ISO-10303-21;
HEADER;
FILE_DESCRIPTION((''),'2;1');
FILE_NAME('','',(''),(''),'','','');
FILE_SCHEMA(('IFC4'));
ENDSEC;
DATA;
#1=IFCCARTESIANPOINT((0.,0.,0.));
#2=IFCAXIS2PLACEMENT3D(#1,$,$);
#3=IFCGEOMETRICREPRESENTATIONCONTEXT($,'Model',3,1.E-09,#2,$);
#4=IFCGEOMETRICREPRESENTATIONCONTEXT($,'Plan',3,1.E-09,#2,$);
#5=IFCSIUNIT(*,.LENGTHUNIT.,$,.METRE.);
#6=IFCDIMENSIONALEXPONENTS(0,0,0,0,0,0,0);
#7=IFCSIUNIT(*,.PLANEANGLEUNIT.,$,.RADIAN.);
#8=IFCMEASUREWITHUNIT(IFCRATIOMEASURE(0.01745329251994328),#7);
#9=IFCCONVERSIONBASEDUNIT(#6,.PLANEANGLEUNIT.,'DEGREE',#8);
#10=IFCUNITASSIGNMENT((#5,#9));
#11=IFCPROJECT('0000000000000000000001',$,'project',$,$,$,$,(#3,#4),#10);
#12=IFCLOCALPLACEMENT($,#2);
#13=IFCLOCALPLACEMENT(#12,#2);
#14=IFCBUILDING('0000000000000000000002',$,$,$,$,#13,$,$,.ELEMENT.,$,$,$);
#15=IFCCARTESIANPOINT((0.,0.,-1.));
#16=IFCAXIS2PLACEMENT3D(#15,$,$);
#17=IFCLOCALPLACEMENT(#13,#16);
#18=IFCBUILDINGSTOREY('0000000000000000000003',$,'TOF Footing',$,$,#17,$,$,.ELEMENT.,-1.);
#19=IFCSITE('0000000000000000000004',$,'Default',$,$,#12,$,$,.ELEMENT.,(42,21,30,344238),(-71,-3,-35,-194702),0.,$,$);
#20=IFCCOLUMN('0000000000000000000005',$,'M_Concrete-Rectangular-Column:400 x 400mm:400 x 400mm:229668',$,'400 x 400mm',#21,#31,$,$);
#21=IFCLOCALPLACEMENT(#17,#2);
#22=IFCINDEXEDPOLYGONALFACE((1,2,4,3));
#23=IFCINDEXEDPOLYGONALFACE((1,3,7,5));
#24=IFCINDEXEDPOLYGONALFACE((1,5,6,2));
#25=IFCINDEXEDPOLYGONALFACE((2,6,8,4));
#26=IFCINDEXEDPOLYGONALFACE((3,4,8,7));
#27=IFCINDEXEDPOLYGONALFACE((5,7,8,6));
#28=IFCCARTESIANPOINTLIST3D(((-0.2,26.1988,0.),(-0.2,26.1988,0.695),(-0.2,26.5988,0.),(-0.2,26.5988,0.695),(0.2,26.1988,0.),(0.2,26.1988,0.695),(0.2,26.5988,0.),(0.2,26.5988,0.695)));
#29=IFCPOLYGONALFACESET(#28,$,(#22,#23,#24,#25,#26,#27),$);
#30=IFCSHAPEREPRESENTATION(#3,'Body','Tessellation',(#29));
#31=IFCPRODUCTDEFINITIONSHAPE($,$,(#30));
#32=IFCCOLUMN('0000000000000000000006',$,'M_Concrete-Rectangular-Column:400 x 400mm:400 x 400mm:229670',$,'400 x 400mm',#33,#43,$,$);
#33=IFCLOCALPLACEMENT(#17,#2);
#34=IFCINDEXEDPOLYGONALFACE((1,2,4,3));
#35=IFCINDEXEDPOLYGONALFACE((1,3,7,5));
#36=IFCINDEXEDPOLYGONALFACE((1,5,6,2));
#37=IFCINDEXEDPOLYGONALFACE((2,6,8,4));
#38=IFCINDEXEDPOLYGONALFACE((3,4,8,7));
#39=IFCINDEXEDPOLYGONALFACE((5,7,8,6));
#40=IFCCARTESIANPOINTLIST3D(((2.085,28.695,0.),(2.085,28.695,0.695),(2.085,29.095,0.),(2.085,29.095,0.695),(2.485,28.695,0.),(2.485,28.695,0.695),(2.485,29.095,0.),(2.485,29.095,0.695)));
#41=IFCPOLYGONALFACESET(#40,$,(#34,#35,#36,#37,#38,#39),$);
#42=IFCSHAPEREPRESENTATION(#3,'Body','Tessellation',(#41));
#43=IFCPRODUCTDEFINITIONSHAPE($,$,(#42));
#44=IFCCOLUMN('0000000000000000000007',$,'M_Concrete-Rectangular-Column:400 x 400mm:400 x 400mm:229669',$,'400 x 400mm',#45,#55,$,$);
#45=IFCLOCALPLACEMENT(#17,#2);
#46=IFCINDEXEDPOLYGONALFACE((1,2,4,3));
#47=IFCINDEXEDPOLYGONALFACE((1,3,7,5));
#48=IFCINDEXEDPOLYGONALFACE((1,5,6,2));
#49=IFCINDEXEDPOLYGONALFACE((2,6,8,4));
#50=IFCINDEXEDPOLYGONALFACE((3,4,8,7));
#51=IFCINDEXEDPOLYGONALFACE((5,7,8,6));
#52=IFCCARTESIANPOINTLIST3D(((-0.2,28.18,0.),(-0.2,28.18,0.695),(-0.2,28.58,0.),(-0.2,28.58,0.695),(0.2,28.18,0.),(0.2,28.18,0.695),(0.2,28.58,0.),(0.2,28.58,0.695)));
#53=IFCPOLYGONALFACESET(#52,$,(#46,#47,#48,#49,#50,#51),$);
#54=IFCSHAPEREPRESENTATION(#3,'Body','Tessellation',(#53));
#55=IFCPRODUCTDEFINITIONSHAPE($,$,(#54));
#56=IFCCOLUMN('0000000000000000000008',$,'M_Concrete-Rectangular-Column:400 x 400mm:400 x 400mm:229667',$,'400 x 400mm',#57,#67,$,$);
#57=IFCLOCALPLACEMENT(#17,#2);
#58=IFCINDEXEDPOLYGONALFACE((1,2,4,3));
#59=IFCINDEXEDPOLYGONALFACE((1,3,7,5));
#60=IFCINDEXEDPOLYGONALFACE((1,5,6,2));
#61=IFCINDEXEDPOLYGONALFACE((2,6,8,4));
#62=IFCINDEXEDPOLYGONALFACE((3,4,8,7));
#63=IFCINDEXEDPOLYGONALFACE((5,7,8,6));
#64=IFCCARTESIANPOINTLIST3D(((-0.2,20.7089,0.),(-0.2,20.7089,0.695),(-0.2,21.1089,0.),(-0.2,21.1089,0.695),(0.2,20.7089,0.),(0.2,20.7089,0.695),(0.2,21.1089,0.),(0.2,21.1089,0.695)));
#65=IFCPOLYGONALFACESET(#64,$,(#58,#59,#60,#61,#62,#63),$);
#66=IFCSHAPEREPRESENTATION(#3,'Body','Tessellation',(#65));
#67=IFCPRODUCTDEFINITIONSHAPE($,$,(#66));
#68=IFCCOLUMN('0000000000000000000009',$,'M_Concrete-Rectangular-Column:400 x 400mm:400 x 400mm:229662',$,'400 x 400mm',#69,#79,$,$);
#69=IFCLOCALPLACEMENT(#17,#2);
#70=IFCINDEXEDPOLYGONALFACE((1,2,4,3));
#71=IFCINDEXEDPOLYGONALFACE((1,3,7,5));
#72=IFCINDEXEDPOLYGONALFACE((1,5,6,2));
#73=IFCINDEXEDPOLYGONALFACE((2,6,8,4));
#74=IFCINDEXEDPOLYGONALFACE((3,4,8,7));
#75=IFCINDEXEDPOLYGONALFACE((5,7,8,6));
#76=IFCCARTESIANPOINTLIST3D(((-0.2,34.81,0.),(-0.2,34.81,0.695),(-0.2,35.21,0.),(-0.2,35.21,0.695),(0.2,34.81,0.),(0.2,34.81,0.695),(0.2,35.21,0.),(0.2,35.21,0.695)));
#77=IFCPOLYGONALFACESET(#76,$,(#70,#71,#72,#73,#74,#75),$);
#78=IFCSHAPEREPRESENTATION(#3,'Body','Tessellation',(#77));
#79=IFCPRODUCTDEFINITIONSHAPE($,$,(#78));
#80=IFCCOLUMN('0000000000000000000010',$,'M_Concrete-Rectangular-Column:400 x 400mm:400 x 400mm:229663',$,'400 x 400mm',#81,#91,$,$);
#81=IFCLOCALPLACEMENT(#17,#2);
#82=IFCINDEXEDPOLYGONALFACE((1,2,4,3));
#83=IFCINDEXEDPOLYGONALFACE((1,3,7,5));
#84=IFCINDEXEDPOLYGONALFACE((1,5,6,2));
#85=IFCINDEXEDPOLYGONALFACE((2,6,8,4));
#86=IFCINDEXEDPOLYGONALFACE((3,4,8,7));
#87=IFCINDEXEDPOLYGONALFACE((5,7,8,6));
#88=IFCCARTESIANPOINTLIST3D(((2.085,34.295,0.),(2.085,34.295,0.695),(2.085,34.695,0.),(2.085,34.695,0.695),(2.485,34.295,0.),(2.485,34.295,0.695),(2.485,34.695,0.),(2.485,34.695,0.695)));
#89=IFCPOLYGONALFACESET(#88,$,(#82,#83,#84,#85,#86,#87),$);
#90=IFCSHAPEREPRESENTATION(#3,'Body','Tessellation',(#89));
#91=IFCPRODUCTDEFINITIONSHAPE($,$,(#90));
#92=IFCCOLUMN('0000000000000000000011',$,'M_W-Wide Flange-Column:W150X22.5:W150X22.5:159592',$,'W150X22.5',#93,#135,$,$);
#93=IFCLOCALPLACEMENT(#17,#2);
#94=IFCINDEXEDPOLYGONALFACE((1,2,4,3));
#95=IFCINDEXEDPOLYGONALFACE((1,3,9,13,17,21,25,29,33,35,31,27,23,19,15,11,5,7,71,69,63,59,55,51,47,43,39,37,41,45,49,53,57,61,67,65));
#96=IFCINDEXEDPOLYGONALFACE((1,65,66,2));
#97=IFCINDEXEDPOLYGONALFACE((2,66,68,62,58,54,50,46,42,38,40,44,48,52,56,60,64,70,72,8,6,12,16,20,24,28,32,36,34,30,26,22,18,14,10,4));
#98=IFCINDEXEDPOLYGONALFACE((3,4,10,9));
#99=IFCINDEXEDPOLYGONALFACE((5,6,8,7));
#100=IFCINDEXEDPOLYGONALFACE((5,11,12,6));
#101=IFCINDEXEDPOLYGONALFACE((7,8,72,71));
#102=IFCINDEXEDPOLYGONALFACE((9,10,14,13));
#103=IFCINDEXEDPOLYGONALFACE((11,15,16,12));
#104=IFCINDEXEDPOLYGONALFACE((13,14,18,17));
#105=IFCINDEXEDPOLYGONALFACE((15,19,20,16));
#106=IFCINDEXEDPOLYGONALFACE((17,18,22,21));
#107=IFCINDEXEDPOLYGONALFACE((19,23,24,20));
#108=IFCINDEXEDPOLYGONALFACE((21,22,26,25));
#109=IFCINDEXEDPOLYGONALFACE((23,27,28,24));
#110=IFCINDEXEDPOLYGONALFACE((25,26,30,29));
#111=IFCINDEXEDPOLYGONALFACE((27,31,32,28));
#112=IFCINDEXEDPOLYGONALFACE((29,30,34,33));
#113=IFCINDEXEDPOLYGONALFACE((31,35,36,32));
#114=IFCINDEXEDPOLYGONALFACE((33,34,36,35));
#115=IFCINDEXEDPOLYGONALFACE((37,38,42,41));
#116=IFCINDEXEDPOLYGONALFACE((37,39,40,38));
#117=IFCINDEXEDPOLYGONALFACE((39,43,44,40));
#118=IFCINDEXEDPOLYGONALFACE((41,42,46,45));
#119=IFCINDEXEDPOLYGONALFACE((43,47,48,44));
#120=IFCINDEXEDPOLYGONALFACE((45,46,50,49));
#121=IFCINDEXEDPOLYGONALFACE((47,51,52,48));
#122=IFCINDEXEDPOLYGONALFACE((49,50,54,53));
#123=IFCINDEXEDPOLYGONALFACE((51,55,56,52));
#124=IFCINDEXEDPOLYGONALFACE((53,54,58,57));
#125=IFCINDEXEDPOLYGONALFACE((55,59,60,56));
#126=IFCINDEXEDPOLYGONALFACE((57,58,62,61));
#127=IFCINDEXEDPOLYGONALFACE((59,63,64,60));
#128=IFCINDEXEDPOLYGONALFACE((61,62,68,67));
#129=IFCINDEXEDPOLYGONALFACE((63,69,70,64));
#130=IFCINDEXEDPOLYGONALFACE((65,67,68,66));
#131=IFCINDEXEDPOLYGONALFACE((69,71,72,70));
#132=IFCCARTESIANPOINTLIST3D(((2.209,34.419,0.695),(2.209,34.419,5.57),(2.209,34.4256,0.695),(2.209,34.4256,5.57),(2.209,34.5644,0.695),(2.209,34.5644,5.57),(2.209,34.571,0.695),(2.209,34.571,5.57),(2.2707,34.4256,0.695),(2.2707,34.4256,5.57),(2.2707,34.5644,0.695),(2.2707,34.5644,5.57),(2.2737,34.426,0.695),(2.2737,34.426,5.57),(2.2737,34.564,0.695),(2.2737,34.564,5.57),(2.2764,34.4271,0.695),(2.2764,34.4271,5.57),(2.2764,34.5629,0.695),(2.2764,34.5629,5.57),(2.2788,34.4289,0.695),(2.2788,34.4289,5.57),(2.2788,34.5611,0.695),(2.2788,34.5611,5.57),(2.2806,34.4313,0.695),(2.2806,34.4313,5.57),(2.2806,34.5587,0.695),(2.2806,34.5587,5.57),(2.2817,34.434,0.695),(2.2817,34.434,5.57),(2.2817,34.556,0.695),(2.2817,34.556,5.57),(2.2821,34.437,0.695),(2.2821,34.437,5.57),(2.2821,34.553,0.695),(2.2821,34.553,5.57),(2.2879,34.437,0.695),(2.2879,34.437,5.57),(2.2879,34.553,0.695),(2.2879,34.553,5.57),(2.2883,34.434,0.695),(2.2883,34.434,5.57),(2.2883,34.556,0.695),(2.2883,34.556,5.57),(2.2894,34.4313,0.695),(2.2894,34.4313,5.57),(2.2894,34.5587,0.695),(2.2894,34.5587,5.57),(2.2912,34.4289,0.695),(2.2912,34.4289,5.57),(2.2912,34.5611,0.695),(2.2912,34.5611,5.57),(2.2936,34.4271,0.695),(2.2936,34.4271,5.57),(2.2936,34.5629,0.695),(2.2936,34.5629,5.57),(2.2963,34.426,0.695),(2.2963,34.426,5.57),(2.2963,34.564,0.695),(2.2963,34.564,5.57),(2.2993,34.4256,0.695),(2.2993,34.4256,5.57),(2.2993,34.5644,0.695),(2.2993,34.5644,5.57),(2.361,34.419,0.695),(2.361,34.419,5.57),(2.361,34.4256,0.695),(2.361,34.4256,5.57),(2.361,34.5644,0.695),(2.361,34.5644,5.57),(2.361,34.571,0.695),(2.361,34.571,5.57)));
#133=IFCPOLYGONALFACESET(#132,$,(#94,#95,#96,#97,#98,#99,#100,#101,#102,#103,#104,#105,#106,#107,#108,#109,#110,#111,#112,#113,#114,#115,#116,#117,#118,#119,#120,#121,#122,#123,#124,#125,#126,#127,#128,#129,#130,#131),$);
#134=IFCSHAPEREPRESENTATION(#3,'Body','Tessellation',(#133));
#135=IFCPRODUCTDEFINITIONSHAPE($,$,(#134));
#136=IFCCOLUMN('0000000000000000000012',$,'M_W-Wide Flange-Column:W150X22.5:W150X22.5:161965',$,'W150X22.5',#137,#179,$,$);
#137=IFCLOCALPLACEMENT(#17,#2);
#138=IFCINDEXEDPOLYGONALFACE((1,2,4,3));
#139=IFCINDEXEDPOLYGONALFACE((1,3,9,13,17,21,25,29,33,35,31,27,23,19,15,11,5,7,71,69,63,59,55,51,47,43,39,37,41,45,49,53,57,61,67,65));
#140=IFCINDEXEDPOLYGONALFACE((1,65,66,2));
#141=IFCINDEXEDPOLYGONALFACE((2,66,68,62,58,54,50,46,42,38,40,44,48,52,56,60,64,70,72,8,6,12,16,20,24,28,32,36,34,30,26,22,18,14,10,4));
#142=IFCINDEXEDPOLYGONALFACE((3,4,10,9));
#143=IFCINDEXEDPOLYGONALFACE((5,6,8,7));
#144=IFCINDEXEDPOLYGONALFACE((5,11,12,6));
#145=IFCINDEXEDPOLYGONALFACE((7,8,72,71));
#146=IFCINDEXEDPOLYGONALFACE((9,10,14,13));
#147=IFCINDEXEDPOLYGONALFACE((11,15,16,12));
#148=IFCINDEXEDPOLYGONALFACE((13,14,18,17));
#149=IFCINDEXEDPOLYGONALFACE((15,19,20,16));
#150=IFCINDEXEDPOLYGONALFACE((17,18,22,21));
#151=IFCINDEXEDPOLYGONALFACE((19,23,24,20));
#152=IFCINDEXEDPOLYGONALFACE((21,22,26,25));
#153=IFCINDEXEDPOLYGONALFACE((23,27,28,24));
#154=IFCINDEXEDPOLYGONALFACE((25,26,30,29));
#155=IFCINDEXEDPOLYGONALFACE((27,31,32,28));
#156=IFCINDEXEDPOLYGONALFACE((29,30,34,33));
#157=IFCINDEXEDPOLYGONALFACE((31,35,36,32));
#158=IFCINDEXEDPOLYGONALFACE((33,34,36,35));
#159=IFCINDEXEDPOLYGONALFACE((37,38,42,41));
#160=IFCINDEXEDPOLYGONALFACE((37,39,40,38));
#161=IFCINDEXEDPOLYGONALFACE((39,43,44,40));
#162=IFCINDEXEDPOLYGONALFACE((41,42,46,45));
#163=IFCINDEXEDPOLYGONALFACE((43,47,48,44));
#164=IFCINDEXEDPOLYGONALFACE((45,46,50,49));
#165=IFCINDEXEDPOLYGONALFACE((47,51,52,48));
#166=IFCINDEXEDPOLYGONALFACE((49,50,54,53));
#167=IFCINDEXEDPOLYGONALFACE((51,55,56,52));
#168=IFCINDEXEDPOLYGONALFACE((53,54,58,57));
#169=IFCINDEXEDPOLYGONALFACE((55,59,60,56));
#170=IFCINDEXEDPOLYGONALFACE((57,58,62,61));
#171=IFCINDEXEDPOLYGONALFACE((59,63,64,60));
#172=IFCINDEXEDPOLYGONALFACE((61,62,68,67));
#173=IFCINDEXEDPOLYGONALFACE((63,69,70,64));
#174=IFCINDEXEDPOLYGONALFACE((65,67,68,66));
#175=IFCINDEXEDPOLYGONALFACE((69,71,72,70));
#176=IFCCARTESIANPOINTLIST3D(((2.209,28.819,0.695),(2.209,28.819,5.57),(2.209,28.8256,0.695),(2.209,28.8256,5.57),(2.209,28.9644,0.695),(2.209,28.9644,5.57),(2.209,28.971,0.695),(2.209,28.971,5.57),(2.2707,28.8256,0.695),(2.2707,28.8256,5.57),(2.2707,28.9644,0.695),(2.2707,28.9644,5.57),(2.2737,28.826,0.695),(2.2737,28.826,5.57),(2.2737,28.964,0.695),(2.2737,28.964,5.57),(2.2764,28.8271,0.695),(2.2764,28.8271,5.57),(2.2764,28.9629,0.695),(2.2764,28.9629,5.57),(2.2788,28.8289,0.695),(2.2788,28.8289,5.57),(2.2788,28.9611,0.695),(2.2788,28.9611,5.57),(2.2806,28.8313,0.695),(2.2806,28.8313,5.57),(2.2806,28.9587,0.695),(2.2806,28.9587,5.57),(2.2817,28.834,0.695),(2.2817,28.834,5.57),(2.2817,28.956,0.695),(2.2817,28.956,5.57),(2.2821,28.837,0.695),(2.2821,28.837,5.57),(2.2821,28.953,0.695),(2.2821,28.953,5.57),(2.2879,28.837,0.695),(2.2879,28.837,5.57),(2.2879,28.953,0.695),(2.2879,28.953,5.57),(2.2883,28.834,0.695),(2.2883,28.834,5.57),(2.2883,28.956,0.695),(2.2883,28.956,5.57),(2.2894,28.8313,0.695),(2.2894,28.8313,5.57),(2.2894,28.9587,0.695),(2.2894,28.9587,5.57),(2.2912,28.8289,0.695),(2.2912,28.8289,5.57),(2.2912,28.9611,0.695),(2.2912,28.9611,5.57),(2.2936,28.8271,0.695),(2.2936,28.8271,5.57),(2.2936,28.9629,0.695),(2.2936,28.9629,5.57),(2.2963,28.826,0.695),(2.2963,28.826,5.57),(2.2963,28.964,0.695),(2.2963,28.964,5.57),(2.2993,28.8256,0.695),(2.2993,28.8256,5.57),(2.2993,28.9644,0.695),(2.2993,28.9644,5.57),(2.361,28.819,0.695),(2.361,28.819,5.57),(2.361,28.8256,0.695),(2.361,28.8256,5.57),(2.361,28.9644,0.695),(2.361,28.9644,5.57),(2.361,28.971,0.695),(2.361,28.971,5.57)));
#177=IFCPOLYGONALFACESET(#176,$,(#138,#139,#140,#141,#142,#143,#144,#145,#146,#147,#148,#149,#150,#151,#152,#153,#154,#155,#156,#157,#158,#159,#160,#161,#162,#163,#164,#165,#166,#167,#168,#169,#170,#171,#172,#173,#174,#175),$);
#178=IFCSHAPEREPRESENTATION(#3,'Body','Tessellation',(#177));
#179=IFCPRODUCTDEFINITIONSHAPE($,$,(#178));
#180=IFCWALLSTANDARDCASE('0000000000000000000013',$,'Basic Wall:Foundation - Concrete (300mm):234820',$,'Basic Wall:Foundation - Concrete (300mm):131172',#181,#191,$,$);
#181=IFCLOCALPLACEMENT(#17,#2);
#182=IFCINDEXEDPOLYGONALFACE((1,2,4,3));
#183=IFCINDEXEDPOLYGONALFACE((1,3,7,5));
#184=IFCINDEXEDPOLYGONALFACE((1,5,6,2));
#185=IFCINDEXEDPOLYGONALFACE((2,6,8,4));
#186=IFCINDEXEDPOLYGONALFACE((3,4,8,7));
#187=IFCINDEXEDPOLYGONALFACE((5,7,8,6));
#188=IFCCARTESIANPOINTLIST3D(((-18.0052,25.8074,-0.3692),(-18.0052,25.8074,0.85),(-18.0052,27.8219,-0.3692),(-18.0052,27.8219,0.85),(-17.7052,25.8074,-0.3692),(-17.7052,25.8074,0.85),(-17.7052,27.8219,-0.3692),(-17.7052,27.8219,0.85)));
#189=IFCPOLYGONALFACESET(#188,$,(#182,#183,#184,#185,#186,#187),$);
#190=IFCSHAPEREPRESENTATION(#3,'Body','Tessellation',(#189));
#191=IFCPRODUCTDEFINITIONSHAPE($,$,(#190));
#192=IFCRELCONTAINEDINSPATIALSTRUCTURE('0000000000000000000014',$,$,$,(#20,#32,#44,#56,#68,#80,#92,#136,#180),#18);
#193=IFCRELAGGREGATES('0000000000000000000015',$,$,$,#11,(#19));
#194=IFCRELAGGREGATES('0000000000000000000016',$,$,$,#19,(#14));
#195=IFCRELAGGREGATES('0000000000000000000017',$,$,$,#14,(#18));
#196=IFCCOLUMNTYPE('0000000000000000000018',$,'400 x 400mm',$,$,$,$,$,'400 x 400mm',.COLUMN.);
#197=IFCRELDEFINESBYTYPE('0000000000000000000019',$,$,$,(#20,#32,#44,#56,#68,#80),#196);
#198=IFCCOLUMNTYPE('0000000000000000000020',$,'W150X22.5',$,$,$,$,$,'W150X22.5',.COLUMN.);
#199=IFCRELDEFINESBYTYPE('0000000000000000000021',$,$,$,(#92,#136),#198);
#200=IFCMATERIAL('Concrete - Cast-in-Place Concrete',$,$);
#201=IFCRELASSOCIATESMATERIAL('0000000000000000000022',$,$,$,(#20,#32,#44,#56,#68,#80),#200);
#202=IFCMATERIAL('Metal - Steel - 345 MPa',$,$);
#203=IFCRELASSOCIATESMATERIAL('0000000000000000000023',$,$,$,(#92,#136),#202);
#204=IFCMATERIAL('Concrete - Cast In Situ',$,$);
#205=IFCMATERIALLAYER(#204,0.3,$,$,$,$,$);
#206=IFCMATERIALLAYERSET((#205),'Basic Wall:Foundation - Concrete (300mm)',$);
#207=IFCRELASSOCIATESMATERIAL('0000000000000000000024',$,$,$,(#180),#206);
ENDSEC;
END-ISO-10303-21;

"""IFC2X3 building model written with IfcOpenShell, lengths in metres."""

from ifc_helpers import new_model, entity, si_unit, converted_unit, frame, frame_2d, origin, place, context, project, spatial, polyline, circle_curve, parameter, trimmed, segment, composite_curve, rectangle, outline, extrude, source, transform, mapped, material, layer, layer_set, layer_usage, type_object, type_shapes, element, save


model = new_model("IFC2X3")

# Units and contexts
model_context = context("Model", 3, precision=1e-09, world=origin())
plan_context = context("Plan", 3, precision=1e-09, world=origin())
ifc_project = project(units=[si_unit("LENGTHUNIT", "METRE"), converted_unit("PLANEANGLEUNIT", "DEGREE", entity("IfcRatioMeasure", 0.01745329251994328), si_unit("PLANEANGLEUNIT", "RADIAN"), dimensions=[0, 0, 0, 0, 0, 0, 0])], contexts=[model_context, plan_context])

# Site, building, storey
site_placement = place(None, origin())
site = spatial("IfcSite", under=ifc_project, at=site_placement, Name="Default", CompositionType="ELEMENT", RefLatitude=(42, 21, 30, 344238), RefLongitude=(-71, -3, -35, -194702), RefElevation=0.0)
building_placement = place(site_placement, origin())
building = spatial("IfcBuilding", under=site, at=building_placement, CompositionType="ELEMENT")
storey_placement = place(building_placement, frame((0.0, 0.0, -1.0)))
storey = spatial("IfcBuildingStorey", under=building, at=storey_placement, Name="TOF Footing", CompositionType="ELEMENT", Elevation=-1.0)

# Columns
ifc_material_1 = material(Name="Metal - Steel - 345 MPa")
ifc_material_2 = material(Name="Concrete - Cast-in-Place Concrete")
column_type_1 = type_object("IfcColumnType", Name="400 x 400mm", ElementType="400 x 400mm", PredefinedType="COLUMN")
shared_shape_1 = source(origin(), model_context, "Body", "SweptSolid", [
    extrude(rectangle(XDim=0.4, YDim=0.4, at=frame_2d((0.0, 0.0), x_axis=(0.0, -1.0))), origin(), (0.0, 0.0, 1.0), 0.695),
])
type_shapes(column_type_1, [shared_shape_1])
for number, where, name in (
    (1, (0.0, 26.3988, 0.0), "M_Concrete-Rectangular-Column:400 x 400mm:400 x 400mm:229668"),
    (2, (2.285, 28.895, 0.0), "M_Concrete-Rectangular-Column:400 x 400mm:400 x 400mm:229670"),
    (3, (0.0, 28.38, 0.0), "M_Concrete-Rectangular-Column:400 x 400mm:400 x 400mm:229669"),
    (4, (0.0, 20.9089, 0.0), "M_Concrete-Rectangular-Column:400 x 400mm:400 x 400mm:229667"),
):
    element("IfcColumn", number, at=place(storey_placement, frame(where)), inside=storey, type_object=column_type_1, material=ifc_material_2, Name=name, ObjectType="400 x 400mm", context=model_context, shape_type="MappedRepresentation", body=[
        mapped(shared_shape_1, transform((0.0, 0.0, 0.0), scale=1.0)),
    ])
for number, where, z_axis, x_axis, name in (
    (5, (0.0, 35.01, 0.0), (0.0, 0.0, 1.0), (-1.0, 0.0, 0.0), "M_Concrete-Rectangular-Column:400 x 400mm:400 x 400mm:229662"),
    (6, (2.285, 34.495, 0.0), (0.0, 0.0, 1.0), (-1.0, 0.0, 0.0), "M_Concrete-Rectangular-Column:400 x 400mm:400 x 400mm:229663"),
):
    element("IfcColumn", number, at=place(storey_placement, frame(where, z_axis=z_axis, x_axis=x_axis)), inside=storey, type_object=column_type_1, material=ifc_material_2, Name=name, ObjectType="400 x 400mm", context=model_context, shape_type="MappedRepresentation", body=[
        mapped(shared_shape_1, transform((0.0, 0.0, 0.0), scale=1.0)),
    ])
column_type_2 = type_object("IfcColumnType", Name="W150X22.5", ElementType="W150X22.5", PredefinedType="COLUMN")
shared_shape_2 = source(origin(), model_context, "Body", "SweptSolid", [
    extrude(outline(composite_curve([segment(polyline([(-0.076, -0.076), (0.076, -0.076)]), True, "CONTINUOUS"), segment(polyline([(0.076, -0.076), (0.076, -0.0694)]), True, "CONTINUOUS"), segment(polyline([(0.076, -0.0694), (0.0143, -0.0694)]), True, "CONTINUOUS"), segment(trimmed(circle_curve(frame_2d((0.0143, -0.058), x_axis=(-1.0, 0.0)), 0.0114), [parameter(0.0)], [parameter(90.0)], True, "PARAMETER"), False, "CONTINUOUS"), segment(polyline([(0.0029, -0.058), (0.0029, 0.058)]), True, "CONTINUOUS"), segment(trimmed(circle_curve(frame_2d((0.0143, 0.058), x_axis=(-1.0, 0.0)), 0.0114), [parameter(270.0)], [parameter(0.0)], True, "PARAMETER"), False, "CONTINUOUS"), segment(polyline([(0.0143, 0.0694), (0.076, 0.0694)]), True, "CONTINUOUS"), segment(polyline([(0.076, 0.0694), (0.076, 0.076)]), True, "CONTINUOUS"), segment(polyline([(0.076, 0.076), (-0.076, 0.076)]), True, "CONTINUOUS"), segment(polyline([(-0.076, 0.076), (-0.076, 0.0694)]), True, "CONTINUOUS"), segment(polyline([(-0.076, 0.0694), (-0.0143, 0.0694)]), True, "CONTINUOUS"), segment(trimmed(circle_curve(frame_2d((-0.0143, 0.058), x_axis=(-1.0, 0.0)), 0.0114), [parameter(180.0)], [parameter(270.0)], True, "PARAMETER"), False, "CONTINUOUS"), segment(polyline([(-0.0029, 0.058), (-0.0029, -0.058)]), True, "CONTINUOUS"), segment(trimmed(circle_curve(frame_2d((-0.0143, -0.058), x_axis=(-1.0, 0.0)), 0.0114), [parameter(90.0)], [parameter(180.0)], True, "PARAMETER"), False, "CONTINUOUS"), segment(polyline([(-0.0143, -0.0694), (-0.076, -0.0694)]), True, "CONTINUOUS"), segment(polyline([(-0.076, -0.0694), (-0.076, -0.076)]), True, "CONTINUOUS")], self_intersect=False)), frame((0.0, 0.0, -0.305), z_axis=(0.0, 0.0, 1.0), x_axis=(-1.0, 0.0, 0.0)), (0.0, 0.0, 1.0), 4.875),
])
type_shapes(column_type_2, [shared_shape_2])
column_1_placement = place(storey_placement, frame((2.285, 34.495, 1.0), z_axis=(0.0, 0.0, 1.0), x_axis=(-1.0, 0.0, 0.0)))
element("IfcColumn", 7, at=column_1_placement, inside=storey, type_object=column_type_2, material=ifc_material_1, Name="M_W-Wide Flange-Column:W150X22.5:W150X22.5:159592", ObjectType="W150X22.5", context=model_context, shape_type="MappedRepresentation", body=[
    mapped(shared_shape_2, transform((0.0, 0.0, 0.0), scale=1.0)),
])
column_2_placement = place(storey_placement, frame((2.285, 28.895, 1.0)))
element("IfcColumn", 8, at=column_2_placement, inside=storey, type_object=column_type_2, material=ifc_material_1, Name="M_W-Wide Flange-Column:W150X22.5:W150X22.5:161965", ObjectType="W150X22.5", context=model_context, shape_type="MappedRepresentation", body=[
    mapped(shared_shape_2, transform((0.0, 0.0, 0.0), scale=1.0)),
])

# Wall
ifc_material_3 = material(Name="Concrete - Cast In Situ")
ifc_layer = layer(ifc_material_3, 0.3)
ifc_layer_set = layer_set([ifc_layer], Name="Basic Wall:Foundation - Concrete (300mm)")
ifc_layer_usage = layer_usage(ifc_layer_set, "AXIS2", "POSITIVE", -0.15)
wall_1_placement = place(storey_placement, frame((-17.8552, 25.8074, -0.3692), z_axis=(0.0, 0.0, 1.0), x_axis=(0.0, 1.0, 0.0)))
element("IfcWallStandardCase", 9, at=wall_1_placement, inside=storey, material=ifc_layer_usage, Name="Basic Wall:Foundation - Concrete (300mm):234820", ObjectType="Basic Wall:Foundation - Concrete (300mm):131172", context=model_context, shape_type="SweptSolid", body=[
    extrude(rectangle(XDim=2.0145, YDim=0.3, at=frame_2d((1.0072, 0.0), x_axis=(-1.0, 0.0))), origin(), (0.0, 0.0, 1.0), 1.2192),
])

save(model, "model.ifc")
